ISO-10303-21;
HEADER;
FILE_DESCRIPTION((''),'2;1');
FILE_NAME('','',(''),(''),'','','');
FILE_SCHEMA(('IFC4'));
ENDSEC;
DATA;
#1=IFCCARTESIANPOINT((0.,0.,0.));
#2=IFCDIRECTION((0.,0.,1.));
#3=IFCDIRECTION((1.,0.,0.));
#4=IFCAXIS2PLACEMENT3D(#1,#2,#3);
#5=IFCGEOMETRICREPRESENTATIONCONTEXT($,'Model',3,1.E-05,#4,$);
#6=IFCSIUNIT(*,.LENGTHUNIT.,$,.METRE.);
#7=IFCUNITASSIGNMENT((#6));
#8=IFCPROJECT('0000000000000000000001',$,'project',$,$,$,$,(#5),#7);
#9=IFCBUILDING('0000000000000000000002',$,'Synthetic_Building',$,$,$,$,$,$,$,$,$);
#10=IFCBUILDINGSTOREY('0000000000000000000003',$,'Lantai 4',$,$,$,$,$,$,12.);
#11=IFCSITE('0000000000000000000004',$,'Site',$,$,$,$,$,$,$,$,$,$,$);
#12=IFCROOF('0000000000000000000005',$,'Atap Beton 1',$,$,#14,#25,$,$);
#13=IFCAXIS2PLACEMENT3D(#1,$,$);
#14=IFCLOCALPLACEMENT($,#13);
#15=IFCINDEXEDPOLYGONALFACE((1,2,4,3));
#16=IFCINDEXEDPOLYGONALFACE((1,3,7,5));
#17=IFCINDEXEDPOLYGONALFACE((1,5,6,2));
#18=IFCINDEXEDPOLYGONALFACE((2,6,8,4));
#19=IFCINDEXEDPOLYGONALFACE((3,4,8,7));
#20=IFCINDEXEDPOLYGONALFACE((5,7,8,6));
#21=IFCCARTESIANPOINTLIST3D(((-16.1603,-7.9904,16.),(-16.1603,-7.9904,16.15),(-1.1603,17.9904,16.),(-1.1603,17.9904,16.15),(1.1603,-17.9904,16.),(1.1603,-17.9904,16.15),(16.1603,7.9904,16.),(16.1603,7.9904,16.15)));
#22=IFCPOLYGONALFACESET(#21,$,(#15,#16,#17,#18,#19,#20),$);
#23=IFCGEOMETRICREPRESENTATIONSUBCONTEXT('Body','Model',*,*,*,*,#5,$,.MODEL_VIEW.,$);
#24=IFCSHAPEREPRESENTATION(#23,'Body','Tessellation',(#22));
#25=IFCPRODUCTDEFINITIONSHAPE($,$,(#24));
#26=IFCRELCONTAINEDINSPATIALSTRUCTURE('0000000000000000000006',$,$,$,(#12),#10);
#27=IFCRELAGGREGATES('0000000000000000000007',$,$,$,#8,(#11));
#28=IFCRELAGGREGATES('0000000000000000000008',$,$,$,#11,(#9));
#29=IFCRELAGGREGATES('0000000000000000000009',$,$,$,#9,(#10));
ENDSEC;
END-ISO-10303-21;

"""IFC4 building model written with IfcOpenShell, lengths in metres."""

from ifc_helpers import new_model, si_unit, frame, origin_with_axes, place, context, subcontext, project, spatial, polyline, outline, extrude, element, save


model = new_model("IFC4")

# Units and contexts
model_context = context("Model", 3, precision=1e-05, world=origin_with_axes())
body_context = subcontext(model_context, "Body", "Model", "MODEL_VIEW")
ifc_project = project(units=[si_unit("LENGTHUNIT", "METRE")], contexts=[model_context])

# Site, building, storey
site = spatial("IfcSite", under=ifc_project, Name="Site")
building = spatial("IfcBuilding", under=site, Name="Synthetic_Building")
storey = spatial("IfcBuildingStorey", under=building, Name="Lantai 4", Elevation=12.0)

# Roof
roof_placement = place(None, origin_with_axes())
element("IfcRoof", 1, at=roof_placement, inside=storey, Name="Atap Beton 1", context=body_context, shape_type="SweptSolid", body=[
    extrude(outline(polyline([(-16.1603, -7.9904), (1.1603, -17.9904), (16.1603, 7.9904), (-1.1603, 17.9904), (-16.1603, -7.9904)])), frame((0.0, 0.0, 16.0), z_axis=(0.0, 0.0, 1.0), x_axis=(1.0, 0.0, 0.0)), (0.0, 0.0, 1.0), 0.15),
])

save(model, "model.ifc")
